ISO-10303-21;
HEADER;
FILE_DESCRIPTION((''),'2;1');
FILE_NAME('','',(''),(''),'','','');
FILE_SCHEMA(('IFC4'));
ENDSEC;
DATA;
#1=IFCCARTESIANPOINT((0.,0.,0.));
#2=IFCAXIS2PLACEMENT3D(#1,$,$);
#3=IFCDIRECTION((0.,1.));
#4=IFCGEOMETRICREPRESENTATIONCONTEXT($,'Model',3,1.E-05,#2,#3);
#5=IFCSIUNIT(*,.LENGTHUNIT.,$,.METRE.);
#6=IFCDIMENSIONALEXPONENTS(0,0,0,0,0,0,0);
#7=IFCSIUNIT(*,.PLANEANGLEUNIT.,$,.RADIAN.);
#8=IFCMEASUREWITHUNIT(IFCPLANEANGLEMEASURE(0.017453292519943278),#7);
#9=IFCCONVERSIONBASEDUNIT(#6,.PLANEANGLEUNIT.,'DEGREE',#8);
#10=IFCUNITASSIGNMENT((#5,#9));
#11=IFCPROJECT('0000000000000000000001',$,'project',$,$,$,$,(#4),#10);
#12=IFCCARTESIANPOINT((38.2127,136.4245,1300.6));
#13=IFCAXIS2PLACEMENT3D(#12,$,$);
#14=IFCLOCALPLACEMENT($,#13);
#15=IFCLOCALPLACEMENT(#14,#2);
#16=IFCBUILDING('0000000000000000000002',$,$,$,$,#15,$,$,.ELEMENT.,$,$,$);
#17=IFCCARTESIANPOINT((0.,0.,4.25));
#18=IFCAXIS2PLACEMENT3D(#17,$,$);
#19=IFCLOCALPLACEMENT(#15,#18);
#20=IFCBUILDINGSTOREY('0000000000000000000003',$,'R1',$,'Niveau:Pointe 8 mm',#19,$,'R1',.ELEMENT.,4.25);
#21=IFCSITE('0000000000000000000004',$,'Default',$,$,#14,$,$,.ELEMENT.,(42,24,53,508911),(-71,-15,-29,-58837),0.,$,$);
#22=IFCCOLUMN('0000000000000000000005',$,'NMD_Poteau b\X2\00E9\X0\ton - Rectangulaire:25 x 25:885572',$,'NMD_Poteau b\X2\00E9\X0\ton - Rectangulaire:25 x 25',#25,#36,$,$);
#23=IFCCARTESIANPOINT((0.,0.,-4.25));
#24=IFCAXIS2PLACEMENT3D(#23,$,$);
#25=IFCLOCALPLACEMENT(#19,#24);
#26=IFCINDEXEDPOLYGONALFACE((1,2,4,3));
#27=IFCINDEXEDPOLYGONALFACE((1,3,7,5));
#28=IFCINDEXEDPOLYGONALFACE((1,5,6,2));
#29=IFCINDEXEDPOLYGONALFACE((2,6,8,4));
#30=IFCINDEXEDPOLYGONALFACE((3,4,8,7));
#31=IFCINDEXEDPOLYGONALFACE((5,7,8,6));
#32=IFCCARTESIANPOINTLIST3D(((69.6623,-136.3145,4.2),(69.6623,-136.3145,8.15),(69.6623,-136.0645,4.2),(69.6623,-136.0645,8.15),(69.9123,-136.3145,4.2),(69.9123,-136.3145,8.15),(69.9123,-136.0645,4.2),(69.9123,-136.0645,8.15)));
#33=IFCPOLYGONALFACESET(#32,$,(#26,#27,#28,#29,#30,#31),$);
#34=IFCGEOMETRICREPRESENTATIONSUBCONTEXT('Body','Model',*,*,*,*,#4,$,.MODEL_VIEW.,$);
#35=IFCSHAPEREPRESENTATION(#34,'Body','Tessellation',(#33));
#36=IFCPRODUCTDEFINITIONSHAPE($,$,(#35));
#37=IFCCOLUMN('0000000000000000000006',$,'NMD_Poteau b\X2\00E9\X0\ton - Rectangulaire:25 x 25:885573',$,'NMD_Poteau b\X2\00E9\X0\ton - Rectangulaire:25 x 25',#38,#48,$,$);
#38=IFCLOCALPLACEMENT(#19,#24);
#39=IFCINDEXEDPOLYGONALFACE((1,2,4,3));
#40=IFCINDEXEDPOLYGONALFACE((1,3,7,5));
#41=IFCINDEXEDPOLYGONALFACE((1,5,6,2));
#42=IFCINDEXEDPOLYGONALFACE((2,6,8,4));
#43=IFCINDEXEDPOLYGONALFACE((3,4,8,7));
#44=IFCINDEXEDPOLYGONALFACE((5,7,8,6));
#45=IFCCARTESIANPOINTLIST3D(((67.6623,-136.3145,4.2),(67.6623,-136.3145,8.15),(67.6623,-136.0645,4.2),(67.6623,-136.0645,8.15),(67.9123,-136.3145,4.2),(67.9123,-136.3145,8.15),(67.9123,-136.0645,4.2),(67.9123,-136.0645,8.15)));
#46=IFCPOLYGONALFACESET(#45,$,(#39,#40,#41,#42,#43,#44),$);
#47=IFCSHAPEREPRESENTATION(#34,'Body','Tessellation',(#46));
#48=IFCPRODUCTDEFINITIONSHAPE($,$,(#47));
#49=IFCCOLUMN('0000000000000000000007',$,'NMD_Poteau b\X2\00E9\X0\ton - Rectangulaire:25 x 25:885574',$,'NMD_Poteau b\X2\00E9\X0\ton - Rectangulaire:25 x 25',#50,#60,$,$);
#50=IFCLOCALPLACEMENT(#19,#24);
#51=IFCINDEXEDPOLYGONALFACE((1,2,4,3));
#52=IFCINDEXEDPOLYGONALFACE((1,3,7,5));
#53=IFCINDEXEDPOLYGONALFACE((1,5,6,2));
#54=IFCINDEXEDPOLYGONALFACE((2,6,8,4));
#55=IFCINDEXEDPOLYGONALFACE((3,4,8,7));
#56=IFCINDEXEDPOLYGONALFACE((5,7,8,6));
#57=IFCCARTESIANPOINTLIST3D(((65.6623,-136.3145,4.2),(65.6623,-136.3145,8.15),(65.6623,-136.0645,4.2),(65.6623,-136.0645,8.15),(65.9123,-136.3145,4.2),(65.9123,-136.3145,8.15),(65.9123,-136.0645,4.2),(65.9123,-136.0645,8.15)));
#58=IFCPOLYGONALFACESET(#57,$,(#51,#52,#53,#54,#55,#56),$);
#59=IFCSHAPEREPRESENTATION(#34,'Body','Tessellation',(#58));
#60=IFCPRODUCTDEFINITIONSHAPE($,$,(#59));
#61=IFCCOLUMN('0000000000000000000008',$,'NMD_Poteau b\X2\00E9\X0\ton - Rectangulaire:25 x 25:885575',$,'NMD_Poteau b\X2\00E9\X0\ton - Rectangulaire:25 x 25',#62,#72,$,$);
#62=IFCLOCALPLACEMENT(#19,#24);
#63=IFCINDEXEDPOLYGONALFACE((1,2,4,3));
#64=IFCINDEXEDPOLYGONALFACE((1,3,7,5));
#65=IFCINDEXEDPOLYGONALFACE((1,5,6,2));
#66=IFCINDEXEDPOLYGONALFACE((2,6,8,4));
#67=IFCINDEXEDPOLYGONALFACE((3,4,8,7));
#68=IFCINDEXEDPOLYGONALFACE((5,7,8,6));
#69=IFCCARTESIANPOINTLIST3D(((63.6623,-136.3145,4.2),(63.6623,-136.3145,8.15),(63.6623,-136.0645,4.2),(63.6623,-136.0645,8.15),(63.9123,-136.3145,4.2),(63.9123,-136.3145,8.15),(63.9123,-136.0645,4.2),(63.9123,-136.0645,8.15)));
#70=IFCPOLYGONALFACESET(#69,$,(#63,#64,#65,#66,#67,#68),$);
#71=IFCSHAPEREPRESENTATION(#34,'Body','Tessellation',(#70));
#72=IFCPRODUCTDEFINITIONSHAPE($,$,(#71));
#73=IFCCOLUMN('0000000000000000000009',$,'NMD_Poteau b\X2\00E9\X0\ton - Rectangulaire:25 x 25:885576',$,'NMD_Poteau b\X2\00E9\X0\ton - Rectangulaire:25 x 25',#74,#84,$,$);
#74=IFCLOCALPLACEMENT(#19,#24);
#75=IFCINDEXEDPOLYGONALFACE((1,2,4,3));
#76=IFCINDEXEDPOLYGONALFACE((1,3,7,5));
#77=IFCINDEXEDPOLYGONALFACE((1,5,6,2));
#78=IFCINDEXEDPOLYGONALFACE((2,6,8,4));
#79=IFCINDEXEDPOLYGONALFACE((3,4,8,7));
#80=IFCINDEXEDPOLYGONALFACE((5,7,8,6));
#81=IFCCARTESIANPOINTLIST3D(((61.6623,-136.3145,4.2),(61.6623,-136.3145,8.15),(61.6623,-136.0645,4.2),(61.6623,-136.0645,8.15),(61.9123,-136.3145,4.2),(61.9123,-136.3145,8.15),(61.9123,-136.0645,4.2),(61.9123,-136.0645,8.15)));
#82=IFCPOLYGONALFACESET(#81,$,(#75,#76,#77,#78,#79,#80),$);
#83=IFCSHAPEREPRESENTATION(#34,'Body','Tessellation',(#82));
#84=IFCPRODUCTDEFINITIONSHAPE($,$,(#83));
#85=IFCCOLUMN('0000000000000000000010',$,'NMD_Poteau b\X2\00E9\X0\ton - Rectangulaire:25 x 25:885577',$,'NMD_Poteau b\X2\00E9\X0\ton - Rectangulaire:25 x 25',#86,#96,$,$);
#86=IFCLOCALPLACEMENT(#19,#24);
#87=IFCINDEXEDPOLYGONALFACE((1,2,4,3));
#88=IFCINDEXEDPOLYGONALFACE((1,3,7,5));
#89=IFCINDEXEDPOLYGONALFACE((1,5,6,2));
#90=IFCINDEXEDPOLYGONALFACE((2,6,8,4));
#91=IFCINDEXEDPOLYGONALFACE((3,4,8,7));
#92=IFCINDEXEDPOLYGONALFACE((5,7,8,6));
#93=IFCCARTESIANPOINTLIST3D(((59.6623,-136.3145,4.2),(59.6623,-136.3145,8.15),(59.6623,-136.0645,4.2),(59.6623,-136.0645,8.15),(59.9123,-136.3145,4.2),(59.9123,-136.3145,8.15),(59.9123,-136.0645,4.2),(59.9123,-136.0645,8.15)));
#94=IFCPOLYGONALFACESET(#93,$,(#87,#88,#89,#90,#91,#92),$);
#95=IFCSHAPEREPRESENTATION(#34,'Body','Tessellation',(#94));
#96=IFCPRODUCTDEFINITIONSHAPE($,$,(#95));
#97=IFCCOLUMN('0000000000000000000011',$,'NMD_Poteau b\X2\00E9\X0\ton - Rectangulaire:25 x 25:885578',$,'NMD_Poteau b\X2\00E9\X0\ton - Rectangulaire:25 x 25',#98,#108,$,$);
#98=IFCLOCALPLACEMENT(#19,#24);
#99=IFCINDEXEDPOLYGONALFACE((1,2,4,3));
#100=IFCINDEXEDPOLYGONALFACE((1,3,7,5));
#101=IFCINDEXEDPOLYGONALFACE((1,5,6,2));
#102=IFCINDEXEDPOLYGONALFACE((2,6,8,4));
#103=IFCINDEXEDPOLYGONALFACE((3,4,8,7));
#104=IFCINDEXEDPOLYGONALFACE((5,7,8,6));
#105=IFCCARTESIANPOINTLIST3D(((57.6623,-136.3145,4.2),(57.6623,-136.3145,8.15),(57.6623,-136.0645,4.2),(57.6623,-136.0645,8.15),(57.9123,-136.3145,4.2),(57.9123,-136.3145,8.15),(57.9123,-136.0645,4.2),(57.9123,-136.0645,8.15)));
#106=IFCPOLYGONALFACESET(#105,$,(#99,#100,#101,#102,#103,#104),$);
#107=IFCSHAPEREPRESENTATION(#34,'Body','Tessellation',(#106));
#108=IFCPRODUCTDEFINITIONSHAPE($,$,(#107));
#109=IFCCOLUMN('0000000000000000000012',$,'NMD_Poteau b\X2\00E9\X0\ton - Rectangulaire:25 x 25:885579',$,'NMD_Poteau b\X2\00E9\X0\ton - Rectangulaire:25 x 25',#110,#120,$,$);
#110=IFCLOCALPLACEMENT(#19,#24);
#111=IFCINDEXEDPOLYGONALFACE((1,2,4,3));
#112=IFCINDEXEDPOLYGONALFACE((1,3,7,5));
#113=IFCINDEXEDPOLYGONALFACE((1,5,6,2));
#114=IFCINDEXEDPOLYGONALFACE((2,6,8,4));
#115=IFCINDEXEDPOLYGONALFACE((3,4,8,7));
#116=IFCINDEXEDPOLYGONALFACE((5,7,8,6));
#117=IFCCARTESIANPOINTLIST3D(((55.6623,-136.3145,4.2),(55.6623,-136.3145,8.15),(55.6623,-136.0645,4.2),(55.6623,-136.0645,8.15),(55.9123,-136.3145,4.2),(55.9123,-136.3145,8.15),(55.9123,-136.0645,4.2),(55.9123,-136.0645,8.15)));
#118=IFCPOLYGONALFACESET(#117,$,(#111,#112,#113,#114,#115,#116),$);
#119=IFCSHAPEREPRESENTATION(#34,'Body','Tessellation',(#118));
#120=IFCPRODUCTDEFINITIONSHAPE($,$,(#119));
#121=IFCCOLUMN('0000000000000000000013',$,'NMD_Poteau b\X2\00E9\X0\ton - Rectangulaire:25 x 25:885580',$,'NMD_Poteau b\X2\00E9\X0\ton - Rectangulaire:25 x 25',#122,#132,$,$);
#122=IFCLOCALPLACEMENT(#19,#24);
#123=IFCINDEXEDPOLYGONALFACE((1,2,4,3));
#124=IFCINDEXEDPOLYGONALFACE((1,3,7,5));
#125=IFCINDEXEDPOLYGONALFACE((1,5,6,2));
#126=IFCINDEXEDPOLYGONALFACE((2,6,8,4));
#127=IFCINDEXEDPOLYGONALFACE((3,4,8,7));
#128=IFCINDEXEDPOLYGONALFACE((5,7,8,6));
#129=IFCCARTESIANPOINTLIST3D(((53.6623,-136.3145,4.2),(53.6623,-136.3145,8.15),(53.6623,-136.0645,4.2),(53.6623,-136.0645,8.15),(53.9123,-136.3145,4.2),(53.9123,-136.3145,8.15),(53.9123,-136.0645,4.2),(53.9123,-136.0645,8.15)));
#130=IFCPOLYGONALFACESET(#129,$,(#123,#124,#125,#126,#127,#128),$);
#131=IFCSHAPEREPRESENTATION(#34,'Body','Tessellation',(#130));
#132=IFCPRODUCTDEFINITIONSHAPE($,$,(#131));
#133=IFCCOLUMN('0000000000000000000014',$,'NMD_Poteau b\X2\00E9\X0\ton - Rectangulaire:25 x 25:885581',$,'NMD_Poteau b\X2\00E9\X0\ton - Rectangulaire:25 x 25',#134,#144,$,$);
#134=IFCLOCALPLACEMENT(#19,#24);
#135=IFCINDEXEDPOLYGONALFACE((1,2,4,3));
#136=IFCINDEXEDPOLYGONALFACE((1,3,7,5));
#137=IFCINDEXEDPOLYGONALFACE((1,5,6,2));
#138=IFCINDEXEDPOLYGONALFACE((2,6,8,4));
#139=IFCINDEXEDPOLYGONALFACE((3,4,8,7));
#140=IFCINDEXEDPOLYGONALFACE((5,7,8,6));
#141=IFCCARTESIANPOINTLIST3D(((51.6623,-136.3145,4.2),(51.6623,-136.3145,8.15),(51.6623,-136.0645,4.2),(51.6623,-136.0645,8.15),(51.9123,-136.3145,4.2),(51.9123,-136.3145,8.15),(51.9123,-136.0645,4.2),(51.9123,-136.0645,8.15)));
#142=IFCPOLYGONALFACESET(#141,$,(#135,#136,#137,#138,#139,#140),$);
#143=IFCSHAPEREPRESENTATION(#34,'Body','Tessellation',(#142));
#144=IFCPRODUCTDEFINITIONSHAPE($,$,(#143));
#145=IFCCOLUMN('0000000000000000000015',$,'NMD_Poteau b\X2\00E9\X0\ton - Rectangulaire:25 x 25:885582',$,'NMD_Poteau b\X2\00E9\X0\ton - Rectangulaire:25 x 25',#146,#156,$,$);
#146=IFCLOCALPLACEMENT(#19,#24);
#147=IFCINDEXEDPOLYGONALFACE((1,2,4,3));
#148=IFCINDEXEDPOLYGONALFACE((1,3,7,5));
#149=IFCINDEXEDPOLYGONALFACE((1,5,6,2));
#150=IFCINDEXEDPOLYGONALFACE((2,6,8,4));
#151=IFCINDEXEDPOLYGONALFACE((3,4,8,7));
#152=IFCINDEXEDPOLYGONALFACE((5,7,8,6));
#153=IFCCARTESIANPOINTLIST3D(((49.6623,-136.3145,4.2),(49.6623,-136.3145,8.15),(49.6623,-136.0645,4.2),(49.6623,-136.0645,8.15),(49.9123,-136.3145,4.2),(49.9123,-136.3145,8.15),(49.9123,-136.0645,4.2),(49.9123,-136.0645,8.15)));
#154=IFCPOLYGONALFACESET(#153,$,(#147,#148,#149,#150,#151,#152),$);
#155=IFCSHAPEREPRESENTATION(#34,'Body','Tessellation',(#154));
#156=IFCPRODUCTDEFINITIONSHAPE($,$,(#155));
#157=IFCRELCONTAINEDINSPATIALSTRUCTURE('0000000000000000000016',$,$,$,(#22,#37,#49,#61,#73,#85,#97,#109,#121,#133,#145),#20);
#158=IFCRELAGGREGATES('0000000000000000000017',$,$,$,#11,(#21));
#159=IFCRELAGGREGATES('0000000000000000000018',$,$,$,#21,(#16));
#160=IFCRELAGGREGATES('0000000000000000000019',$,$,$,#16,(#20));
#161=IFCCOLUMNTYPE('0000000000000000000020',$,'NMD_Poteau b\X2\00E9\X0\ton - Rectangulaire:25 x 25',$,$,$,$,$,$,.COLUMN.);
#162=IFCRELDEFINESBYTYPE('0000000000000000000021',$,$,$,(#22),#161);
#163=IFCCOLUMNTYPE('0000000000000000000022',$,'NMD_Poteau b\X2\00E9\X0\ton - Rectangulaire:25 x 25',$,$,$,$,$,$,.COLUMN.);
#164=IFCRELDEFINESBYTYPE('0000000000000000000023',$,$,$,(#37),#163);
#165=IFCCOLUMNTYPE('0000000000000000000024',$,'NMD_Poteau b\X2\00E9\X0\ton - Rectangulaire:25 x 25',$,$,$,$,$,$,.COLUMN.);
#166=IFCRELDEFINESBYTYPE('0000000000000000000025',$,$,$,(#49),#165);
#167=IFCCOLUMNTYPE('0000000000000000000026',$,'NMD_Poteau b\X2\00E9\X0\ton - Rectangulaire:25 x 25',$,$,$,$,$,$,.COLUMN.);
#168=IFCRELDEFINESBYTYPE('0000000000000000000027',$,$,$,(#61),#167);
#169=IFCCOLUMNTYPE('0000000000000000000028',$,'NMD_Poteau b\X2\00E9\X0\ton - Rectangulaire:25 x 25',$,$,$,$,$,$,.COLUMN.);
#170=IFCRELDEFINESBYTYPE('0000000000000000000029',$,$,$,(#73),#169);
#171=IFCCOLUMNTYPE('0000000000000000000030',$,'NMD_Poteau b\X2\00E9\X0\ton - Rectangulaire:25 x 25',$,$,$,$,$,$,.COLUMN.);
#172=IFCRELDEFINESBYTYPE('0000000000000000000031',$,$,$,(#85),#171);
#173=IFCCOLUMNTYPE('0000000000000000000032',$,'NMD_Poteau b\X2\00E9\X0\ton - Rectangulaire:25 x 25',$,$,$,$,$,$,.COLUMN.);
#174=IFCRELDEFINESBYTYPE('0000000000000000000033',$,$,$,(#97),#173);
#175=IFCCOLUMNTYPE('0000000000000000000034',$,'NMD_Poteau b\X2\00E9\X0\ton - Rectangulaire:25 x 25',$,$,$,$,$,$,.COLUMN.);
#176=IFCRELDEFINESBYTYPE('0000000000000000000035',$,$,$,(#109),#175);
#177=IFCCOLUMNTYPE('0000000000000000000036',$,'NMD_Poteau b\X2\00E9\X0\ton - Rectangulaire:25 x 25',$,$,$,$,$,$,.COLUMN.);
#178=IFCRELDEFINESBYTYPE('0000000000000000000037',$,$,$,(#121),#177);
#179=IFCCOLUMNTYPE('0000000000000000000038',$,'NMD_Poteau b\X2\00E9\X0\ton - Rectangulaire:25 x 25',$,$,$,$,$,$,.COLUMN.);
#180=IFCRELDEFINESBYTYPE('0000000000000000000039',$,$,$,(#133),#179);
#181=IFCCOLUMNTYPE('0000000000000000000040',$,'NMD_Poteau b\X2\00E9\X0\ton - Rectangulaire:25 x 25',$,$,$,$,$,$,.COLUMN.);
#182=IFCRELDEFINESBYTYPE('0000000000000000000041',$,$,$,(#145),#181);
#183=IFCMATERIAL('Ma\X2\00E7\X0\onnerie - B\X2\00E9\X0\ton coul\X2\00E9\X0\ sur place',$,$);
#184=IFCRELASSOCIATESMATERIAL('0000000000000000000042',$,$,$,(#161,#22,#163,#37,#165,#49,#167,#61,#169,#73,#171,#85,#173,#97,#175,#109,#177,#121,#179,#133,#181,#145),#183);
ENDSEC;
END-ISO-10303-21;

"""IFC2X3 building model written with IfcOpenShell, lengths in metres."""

from ifc_helpers import new_model, entity, si_unit, converted_unit, direction, frame, frame_2d, origin, place, context, subcontext, project, spatial, rectangle, extrude, source, transform, mapped, material, type_object, type_shapes, element, save


model = new_model("IFC2X3")

# Units and contexts
model_context = context("Model", 3, precision=1e-05, world=origin(), true_north=direction((0.0, 1.0)))
body_context = subcontext(model_context, "Body", "Model", "MODEL_VIEW")
ifc_project = project(units=[si_unit("LENGTHUNIT", "METRE"), converted_unit("PLANEANGLEUNIT", "DEGREE", entity("IfcPlaneAngleMeasure", 0.017453292519943278), si_unit("PLANEANGLEUNIT", "RADIAN"), dimensions=[0, 0, 0, 0, 0, 0, 0])], contexts=[model_context])

# Site, building, storey
site_placement = place(None, frame((38.2127, 136.4245, 1300.6)))
site = spatial("IfcSite", under=ifc_project, at=site_placement, Name="Default", CompositionType="ELEMENT", RefLatitude=(42, 24, 53, 508911), RefLongitude=(-71, -15, -29, -58837), RefElevation=0.0)
building_placement = place(site_placement, origin())
building = spatial("IfcBuilding", under=site, at=building_placement, CompositionType="ELEMENT")
storey_placement = place(building_placement, frame((0.0, 0.0, 4.25)))
storey = spatial("IfcBuildingStorey", under=building, at=storey_placement, Name="R1", ObjectType="Niveau:Pointe 8 mm", LongName="R1", CompositionType="ELEMENT", Elevation=4.25)

# Columns
ifc_material = material(Name="Maçonnerie - Béton coulé sur place")
column_type_1 = type_object("IfcColumnType", Name="NMD_Poteau béton - Rectangulaire:25 x 25", PredefinedType="COLUMN", material=ifc_material)
shared_shape_1 = source(origin(), body_context, "Body", "SweptSolid", [
    extrude(rectangle(XDim=0.25, YDim=0.25, at=frame_2d((0.0, 0.0), x_axis=(1.0, 0.0))), frame((69.7873, -136.1895, 4.2), z_axis=(0.0, 0.0, 1.0), x_axis=(-1.0, 0.0, 0.0)), (0.0, 0.0, 1.0), 3.95),
])
type_shapes(column_type_1, [shared_shape_1])
column_1_placement = place(storey_placement, frame((0.0, 0.0, -4.25)))
element("IfcColumn", 1, at=column_1_placement, inside=storey, type_object=column_type_1, material=ifc_material, Name="NMD_Poteau béton - Rectangulaire:25 x 25:885572", ObjectType="NMD_Poteau béton - Rectangulaire:25 x 25", context=body_context, shape_type="MappedRepresentation", body=[
    mapped(shared_shape_1, transform((0.0, 0.0, 0.0), scale=1.0)),
])
column_type_2 = type_object("IfcColumnType", Name="NMD_Poteau béton - Rectangulaire:25 x 25", PredefinedType="COLUMN", material=ifc_material)
shared_shape_2 = source(origin(), body_context, "Body", "SweptSolid", [
    extrude(rectangle(XDim=0.25, YDim=0.25, at=frame_2d((0.0, 0.0), x_axis=(1.0, 0.0))), frame((67.7873, -136.1895, 4.2), z_axis=(0.0, 0.0, 1.0), x_axis=(-1.0, 0.0, 0.0)), (0.0, 0.0, 1.0), 3.95),
])
type_shapes(column_type_2, [shared_shape_2])
column_2_placement = place(storey_placement, frame((0.0, 0.0, -4.25)))
element("IfcColumn", 2, at=column_2_placement, inside=storey, type_object=column_type_2, material=ifc_material, Name="NMD_Poteau béton - Rectangulaire:25 x 25:885573", ObjectType="NMD_Poteau béton - Rectangulaire:25 x 25", context=body_context, shape_type="MappedRepresentation", body=[
    mapped(shared_shape_2, transform((0.0, 0.0, 0.0), scale=1.0)),
])
column_type_3 = type_object("IfcColumnType", Name="NMD_Poteau béton - Rectangulaire:25 x 25", PredefinedType="COLUMN", material=ifc_material)
shared_shape_3 = source(origin(), body_context, "Body", "SweptSolid", [
    extrude(rectangle(XDim=0.25, YDim=0.25, at=frame_2d((0.0, 0.0), x_axis=(1.0, 0.0))), frame((65.7873, -136.1895, 4.2), z_axis=(0.0, 0.0, 1.0), x_axis=(-1.0, 0.0, 0.0)), (0.0, 0.0, 1.0), 3.95),
])
type_shapes(column_type_3, [shared_shape_3])
column_3_placement = place(storey_placement, frame((0.0, 0.0, -4.25)))
element("IfcColumn", 3, at=column_3_placement, inside=storey, type_object=column_type_3, material=ifc_material, Name="NMD_Poteau béton - Rectangulaire:25 x 25:885574", ObjectType="NMD_Poteau béton - Rectangulaire:25 x 25", context=body_context, shape_type="MappedRepresentation", body=[
    mapped(shared_shape_3, transform((0.0, 0.0, 0.0), scale=1.0)),
])
column_type_4 = type_object("IfcColumnType", Name="NMD_Poteau béton - Rectangulaire:25 x 25", PredefinedType="COLUMN", material=ifc_material)
shared_shape_4 = source(origin(), body_context, "Body", "SweptSolid", [
    extrude(rectangle(XDim=0.25, YDim=0.25, at=frame_2d((0.0, 0.0), x_axis=(1.0, 0.0))), frame((63.7873, -136.1895, 4.2), z_axis=(0.0, 0.0, 1.0), x_axis=(-1.0, 0.0, 0.0)), (0.0, 0.0, 1.0), 3.95),
])
type_shapes(column_type_4, [shared_shape_4])
column_4_placement = place(storey_placement, frame((0.0, 0.0, -4.25)))
element("IfcColumn", 4, at=column_4_placement, inside=storey, type_object=column_type_4, material=ifc_material, Name="NMD_Poteau béton - Rectangulaire:25 x 25:885575", ObjectType="NMD_Poteau béton - Rectangulaire:25 x 25", context=body_context, shape_type="MappedRepresentation", body=[
    mapped(shared_shape_4, transform((0.0, 0.0, 0.0), scale=1.0)),
])
column_type_5 = type_object("IfcColumnType", Name="NMD_Poteau béton - Rectangulaire:25 x 25", PredefinedType="COLUMN", material=ifc_material)
shared_shape_5 = source(origin(), body_context, "Body", "SweptSolid", [
    extrude(rectangle(XDim=0.25, YDim=0.25, at=frame_2d((0.0, 0.0), x_axis=(1.0, 0.0))), frame((61.7873, -136.1895, 4.2), z_axis=(0.0, 0.0, 1.0), x_axis=(-1.0, 0.0, 0.0)), (0.0, 0.0, 1.0), 3.95),
])
type_shapes(column_type_5, [shared_shape_5])
column_5_placement = place(storey_placement, frame((0.0, 0.0, -4.25)))
element("IfcColumn", 5, at=column_5_placement, inside=storey, type_object=column_type_5, material=ifc_material, Name="NMD_Poteau béton - Rectangulaire:25 x 25:885576", ObjectType="NMD_Poteau béton - Rectangulaire:25 x 25", context=body_context, shape_type="MappedRepresentation", body=[
    mapped(shared_shape_5, transform((0.0, 0.0, 0.0), scale=1.0)),
])
column_type_6 = type_object("IfcColumnType", Name="NMD_Poteau béton - Rectangulaire:25 x 25", PredefinedType="COLUMN", material=ifc_material)
shared_shape_6 = source(origin(), body_context, "Body", "SweptSolid", [
    extrude(rectangle(XDim=0.25, YDim=0.25, at=frame_2d((0.0, 0.0), x_axis=(1.0, 0.0))), frame((59.7873, -136.1895, 4.2), z_axis=(0.0, 0.0, 1.0), x_axis=(-1.0, 0.0, 0.0)), (0.0, 0.0, 1.0), 3.95),
])
type_shapes(column_type_6, [shared_shape_6])
column_6_placement = place(storey_placement, frame((0.0, 0.0, -4.25)))
element("IfcColumn", 6, at=column_6_placement, inside=storey, type_object=column_type_6, material=ifc_material, Name="NMD_Poteau béton - Rectangulaire:25 x 25:885577", ObjectType="NMD_Poteau béton - Rectangulaire:25 x 25", context=body_context, shape_type="MappedRepresentation", body=[
    mapped(shared_shape_6, transform((0.0, 0.0, 0.0), scale=1.0)),
])
column_type_7 = type_object("IfcColumnType", Name="NMD_Poteau béton - Rectangulaire:25 x 25", PredefinedType="COLUMN", material=ifc_material)
shared_shape_7 = source(origin(), body_context, "Body", "SweptSolid", [
    extrude(rectangle(XDim=0.25, YDim=0.25, at=frame_2d((0.0, 0.0), x_axis=(1.0, 0.0))), frame((57.7873, -136.1895, 4.2), z_axis=(0.0, 0.0, 1.0), x_axis=(-1.0, 0.0, 0.0)), (0.0, 0.0, 1.0), 3.95),
])
type_shapes(column_type_7, [shared_shape_7])
column_7_placement = place(storey_placement, frame((0.0, 0.0, -4.25)))
element("IfcColumn", 7, at=column_7_placement, inside=storey, type_object=column_type_7, material=ifc_material, Name="NMD_Poteau béton - Rectangulaire:25 x 25:885578", ObjectType="NMD_Poteau béton - Rectangulaire:25 x 25", context=body_context, shape_type="MappedRepresentation", body=[
    mapped(shared_shape_7, transform((0.0, 0.0, 0.0), scale=1.0)),
])
column_type_8 = type_object("IfcColumnType", Name="NMD_Poteau béton - Rectangulaire:25 x 25", PredefinedType="COLUMN", material=ifc_material)
shared_shape_8 = source(origin(), body_context, "Body", "SweptSolid", [
    extrude(rectangle(XDim=0.25, YDim=0.25, at=frame_2d((0.0, 0.0), x_axis=(1.0, 0.0))), frame((55.7873, -136.1895, 4.2), z_axis=(0.0, 0.0, 1.0), x_axis=(-1.0, 0.0, 0.0)), (0.0, 0.0, 1.0), 3.95),
])
type_shapes(column_type_8, [shared_shape_8])
column_8_placement = place(storey_placement, frame((0.0, 0.0, -4.25)))
element("IfcColumn", 8, at=column_8_placement, inside=storey, type_object=column_type_8, material=ifc_material, Name="NMD_Poteau béton - Rectangulaire:25 x 25:885579", ObjectType="NMD_Poteau béton - Rectangulaire:25 x 25", context=body_context, shape_type="MappedRepresentation", body=[
    mapped(shared_shape_8, transform((0.0, 0.0, 0.0), scale=1.0)),
])
column_type_9 = type_object("IfcColumnType", Name="NMD_Poteau béton - Rectangulaire:25 x 25", PredefinedType="COLUMN", material=ifc_material)
shared_shape_9 = source(origin(), body_context, "Body", "SweptSolid", [
    extrude(rectangle(XDim=0.25, YDim=0.25, at=frame_2d((0.0, 0.0), x_axis=(1.0, 0.0))), frame((53.7873, -136.1895, 4.2), z_axis=(0.0, 0.0, 1.0), x_axis=(-1.0, 0.0, 0.0)), (0.0, 0.0, 1.0), 3.95),
])
type_shapes(column_type_9, [shared_shape_9])
column_9_placement = place(storey_placement, frame((0.0, 0.0, -4.25)))
element("IfcColumn", 9, at=column_9_placement, inside=storey, type_object=column_type_9, material=ifc_material, Name="NMD_Poteau béton - Rectangulaire:25 x 25:885580", ObjectType="NMD_Poteau béton - Rectangulaire:25 x 25", context=body_context, shape_type="MappedRepresentation", body=[
    mapped(shared_shape_9, transform((0.0, 0.0, 0.0), scale=1.0)),
])
column_type_10 = type_object("IfcColumnType", Name="NMD_Poteau béton - Rectangulaire:25 x 25", PredefinedType="COLUMN", material=ifc_material)
shared_shape_10 = source(origin(), body_context, "Body", "SweptSolid", [
    extrude(rectangle(XDim=0.25, YDim=0.25, at=frame_2d((0.0, 0.0), x_axis=(1.0, 0.0))), frame((51.7873, -136.1895, 4.2), z_axis=(0.0, 0.0, 1.0), x_axis=(-1.0, 0.0, 0.0)), (0.0, 0.0, 1.0), 3.95),
])
type_shapes(column_type_10, [shared_shape_10])
column_10_placement = place(storey_placement, frame((0.0, 0.0, -4.25)))
element("IfcColumn", 10, at=column_10_placement, inside=storey, type_object=column_type_10, material=ifc_material, Name="NMD_Poteau béton - Rectangulaire:25 x 25:885581", ObjectType="NMD_Poteau béton - Rectangulaire:25 x 25", context=body_context, shape_type="MappedRepresentation", body=[
    mapped(shared_shape_10, transform((0.0, 0.0, 0.0), scale=1.0)),
])
column_type_11 = type_object("IfcColumnType", Name="NMD_Poteau béton - Rectangulaire:25 x 25", PredefinedType="COLUMN", material=ifc_material)
shared_shape_11 = source(origin(), body_context, "Body", "SweptSolid", [
    extrude(rectangle(XDim=0.25, YDim=0.25, at=frame_2d((0.0, 0.0), x_axis=(1.0, 0.0))), frame((49.7873, -136.1895, 4.2), z_axis=(0.0, 0.0, 1.0), x_axis=(-1.0, 0.0, 0.0)), (0.0, 0.0, 1.0), 3.95),
])
type_shapes(column_type_11, [shared_shape_11])
column_11_placement = place(storey_placement, frame((0.0, 0.0, -4.25)))
element("IfcColumn", 11, at=column_11_placement, inside=storey, type_object=column_type_11, material=ifc_material, Name="NMD_Poteau béton - Rectangulaire:25 x 25:885582", ObjectType="NMD_Poteau béton - Rectangulaire:25 x 25", context=body_context, shape_type="MappedRepresentation", body=[
    mapped(shared_shape_11, transform((0.0, 0.0, 0.0), scale=1.0)),
])

save(model, "model.ifc")
